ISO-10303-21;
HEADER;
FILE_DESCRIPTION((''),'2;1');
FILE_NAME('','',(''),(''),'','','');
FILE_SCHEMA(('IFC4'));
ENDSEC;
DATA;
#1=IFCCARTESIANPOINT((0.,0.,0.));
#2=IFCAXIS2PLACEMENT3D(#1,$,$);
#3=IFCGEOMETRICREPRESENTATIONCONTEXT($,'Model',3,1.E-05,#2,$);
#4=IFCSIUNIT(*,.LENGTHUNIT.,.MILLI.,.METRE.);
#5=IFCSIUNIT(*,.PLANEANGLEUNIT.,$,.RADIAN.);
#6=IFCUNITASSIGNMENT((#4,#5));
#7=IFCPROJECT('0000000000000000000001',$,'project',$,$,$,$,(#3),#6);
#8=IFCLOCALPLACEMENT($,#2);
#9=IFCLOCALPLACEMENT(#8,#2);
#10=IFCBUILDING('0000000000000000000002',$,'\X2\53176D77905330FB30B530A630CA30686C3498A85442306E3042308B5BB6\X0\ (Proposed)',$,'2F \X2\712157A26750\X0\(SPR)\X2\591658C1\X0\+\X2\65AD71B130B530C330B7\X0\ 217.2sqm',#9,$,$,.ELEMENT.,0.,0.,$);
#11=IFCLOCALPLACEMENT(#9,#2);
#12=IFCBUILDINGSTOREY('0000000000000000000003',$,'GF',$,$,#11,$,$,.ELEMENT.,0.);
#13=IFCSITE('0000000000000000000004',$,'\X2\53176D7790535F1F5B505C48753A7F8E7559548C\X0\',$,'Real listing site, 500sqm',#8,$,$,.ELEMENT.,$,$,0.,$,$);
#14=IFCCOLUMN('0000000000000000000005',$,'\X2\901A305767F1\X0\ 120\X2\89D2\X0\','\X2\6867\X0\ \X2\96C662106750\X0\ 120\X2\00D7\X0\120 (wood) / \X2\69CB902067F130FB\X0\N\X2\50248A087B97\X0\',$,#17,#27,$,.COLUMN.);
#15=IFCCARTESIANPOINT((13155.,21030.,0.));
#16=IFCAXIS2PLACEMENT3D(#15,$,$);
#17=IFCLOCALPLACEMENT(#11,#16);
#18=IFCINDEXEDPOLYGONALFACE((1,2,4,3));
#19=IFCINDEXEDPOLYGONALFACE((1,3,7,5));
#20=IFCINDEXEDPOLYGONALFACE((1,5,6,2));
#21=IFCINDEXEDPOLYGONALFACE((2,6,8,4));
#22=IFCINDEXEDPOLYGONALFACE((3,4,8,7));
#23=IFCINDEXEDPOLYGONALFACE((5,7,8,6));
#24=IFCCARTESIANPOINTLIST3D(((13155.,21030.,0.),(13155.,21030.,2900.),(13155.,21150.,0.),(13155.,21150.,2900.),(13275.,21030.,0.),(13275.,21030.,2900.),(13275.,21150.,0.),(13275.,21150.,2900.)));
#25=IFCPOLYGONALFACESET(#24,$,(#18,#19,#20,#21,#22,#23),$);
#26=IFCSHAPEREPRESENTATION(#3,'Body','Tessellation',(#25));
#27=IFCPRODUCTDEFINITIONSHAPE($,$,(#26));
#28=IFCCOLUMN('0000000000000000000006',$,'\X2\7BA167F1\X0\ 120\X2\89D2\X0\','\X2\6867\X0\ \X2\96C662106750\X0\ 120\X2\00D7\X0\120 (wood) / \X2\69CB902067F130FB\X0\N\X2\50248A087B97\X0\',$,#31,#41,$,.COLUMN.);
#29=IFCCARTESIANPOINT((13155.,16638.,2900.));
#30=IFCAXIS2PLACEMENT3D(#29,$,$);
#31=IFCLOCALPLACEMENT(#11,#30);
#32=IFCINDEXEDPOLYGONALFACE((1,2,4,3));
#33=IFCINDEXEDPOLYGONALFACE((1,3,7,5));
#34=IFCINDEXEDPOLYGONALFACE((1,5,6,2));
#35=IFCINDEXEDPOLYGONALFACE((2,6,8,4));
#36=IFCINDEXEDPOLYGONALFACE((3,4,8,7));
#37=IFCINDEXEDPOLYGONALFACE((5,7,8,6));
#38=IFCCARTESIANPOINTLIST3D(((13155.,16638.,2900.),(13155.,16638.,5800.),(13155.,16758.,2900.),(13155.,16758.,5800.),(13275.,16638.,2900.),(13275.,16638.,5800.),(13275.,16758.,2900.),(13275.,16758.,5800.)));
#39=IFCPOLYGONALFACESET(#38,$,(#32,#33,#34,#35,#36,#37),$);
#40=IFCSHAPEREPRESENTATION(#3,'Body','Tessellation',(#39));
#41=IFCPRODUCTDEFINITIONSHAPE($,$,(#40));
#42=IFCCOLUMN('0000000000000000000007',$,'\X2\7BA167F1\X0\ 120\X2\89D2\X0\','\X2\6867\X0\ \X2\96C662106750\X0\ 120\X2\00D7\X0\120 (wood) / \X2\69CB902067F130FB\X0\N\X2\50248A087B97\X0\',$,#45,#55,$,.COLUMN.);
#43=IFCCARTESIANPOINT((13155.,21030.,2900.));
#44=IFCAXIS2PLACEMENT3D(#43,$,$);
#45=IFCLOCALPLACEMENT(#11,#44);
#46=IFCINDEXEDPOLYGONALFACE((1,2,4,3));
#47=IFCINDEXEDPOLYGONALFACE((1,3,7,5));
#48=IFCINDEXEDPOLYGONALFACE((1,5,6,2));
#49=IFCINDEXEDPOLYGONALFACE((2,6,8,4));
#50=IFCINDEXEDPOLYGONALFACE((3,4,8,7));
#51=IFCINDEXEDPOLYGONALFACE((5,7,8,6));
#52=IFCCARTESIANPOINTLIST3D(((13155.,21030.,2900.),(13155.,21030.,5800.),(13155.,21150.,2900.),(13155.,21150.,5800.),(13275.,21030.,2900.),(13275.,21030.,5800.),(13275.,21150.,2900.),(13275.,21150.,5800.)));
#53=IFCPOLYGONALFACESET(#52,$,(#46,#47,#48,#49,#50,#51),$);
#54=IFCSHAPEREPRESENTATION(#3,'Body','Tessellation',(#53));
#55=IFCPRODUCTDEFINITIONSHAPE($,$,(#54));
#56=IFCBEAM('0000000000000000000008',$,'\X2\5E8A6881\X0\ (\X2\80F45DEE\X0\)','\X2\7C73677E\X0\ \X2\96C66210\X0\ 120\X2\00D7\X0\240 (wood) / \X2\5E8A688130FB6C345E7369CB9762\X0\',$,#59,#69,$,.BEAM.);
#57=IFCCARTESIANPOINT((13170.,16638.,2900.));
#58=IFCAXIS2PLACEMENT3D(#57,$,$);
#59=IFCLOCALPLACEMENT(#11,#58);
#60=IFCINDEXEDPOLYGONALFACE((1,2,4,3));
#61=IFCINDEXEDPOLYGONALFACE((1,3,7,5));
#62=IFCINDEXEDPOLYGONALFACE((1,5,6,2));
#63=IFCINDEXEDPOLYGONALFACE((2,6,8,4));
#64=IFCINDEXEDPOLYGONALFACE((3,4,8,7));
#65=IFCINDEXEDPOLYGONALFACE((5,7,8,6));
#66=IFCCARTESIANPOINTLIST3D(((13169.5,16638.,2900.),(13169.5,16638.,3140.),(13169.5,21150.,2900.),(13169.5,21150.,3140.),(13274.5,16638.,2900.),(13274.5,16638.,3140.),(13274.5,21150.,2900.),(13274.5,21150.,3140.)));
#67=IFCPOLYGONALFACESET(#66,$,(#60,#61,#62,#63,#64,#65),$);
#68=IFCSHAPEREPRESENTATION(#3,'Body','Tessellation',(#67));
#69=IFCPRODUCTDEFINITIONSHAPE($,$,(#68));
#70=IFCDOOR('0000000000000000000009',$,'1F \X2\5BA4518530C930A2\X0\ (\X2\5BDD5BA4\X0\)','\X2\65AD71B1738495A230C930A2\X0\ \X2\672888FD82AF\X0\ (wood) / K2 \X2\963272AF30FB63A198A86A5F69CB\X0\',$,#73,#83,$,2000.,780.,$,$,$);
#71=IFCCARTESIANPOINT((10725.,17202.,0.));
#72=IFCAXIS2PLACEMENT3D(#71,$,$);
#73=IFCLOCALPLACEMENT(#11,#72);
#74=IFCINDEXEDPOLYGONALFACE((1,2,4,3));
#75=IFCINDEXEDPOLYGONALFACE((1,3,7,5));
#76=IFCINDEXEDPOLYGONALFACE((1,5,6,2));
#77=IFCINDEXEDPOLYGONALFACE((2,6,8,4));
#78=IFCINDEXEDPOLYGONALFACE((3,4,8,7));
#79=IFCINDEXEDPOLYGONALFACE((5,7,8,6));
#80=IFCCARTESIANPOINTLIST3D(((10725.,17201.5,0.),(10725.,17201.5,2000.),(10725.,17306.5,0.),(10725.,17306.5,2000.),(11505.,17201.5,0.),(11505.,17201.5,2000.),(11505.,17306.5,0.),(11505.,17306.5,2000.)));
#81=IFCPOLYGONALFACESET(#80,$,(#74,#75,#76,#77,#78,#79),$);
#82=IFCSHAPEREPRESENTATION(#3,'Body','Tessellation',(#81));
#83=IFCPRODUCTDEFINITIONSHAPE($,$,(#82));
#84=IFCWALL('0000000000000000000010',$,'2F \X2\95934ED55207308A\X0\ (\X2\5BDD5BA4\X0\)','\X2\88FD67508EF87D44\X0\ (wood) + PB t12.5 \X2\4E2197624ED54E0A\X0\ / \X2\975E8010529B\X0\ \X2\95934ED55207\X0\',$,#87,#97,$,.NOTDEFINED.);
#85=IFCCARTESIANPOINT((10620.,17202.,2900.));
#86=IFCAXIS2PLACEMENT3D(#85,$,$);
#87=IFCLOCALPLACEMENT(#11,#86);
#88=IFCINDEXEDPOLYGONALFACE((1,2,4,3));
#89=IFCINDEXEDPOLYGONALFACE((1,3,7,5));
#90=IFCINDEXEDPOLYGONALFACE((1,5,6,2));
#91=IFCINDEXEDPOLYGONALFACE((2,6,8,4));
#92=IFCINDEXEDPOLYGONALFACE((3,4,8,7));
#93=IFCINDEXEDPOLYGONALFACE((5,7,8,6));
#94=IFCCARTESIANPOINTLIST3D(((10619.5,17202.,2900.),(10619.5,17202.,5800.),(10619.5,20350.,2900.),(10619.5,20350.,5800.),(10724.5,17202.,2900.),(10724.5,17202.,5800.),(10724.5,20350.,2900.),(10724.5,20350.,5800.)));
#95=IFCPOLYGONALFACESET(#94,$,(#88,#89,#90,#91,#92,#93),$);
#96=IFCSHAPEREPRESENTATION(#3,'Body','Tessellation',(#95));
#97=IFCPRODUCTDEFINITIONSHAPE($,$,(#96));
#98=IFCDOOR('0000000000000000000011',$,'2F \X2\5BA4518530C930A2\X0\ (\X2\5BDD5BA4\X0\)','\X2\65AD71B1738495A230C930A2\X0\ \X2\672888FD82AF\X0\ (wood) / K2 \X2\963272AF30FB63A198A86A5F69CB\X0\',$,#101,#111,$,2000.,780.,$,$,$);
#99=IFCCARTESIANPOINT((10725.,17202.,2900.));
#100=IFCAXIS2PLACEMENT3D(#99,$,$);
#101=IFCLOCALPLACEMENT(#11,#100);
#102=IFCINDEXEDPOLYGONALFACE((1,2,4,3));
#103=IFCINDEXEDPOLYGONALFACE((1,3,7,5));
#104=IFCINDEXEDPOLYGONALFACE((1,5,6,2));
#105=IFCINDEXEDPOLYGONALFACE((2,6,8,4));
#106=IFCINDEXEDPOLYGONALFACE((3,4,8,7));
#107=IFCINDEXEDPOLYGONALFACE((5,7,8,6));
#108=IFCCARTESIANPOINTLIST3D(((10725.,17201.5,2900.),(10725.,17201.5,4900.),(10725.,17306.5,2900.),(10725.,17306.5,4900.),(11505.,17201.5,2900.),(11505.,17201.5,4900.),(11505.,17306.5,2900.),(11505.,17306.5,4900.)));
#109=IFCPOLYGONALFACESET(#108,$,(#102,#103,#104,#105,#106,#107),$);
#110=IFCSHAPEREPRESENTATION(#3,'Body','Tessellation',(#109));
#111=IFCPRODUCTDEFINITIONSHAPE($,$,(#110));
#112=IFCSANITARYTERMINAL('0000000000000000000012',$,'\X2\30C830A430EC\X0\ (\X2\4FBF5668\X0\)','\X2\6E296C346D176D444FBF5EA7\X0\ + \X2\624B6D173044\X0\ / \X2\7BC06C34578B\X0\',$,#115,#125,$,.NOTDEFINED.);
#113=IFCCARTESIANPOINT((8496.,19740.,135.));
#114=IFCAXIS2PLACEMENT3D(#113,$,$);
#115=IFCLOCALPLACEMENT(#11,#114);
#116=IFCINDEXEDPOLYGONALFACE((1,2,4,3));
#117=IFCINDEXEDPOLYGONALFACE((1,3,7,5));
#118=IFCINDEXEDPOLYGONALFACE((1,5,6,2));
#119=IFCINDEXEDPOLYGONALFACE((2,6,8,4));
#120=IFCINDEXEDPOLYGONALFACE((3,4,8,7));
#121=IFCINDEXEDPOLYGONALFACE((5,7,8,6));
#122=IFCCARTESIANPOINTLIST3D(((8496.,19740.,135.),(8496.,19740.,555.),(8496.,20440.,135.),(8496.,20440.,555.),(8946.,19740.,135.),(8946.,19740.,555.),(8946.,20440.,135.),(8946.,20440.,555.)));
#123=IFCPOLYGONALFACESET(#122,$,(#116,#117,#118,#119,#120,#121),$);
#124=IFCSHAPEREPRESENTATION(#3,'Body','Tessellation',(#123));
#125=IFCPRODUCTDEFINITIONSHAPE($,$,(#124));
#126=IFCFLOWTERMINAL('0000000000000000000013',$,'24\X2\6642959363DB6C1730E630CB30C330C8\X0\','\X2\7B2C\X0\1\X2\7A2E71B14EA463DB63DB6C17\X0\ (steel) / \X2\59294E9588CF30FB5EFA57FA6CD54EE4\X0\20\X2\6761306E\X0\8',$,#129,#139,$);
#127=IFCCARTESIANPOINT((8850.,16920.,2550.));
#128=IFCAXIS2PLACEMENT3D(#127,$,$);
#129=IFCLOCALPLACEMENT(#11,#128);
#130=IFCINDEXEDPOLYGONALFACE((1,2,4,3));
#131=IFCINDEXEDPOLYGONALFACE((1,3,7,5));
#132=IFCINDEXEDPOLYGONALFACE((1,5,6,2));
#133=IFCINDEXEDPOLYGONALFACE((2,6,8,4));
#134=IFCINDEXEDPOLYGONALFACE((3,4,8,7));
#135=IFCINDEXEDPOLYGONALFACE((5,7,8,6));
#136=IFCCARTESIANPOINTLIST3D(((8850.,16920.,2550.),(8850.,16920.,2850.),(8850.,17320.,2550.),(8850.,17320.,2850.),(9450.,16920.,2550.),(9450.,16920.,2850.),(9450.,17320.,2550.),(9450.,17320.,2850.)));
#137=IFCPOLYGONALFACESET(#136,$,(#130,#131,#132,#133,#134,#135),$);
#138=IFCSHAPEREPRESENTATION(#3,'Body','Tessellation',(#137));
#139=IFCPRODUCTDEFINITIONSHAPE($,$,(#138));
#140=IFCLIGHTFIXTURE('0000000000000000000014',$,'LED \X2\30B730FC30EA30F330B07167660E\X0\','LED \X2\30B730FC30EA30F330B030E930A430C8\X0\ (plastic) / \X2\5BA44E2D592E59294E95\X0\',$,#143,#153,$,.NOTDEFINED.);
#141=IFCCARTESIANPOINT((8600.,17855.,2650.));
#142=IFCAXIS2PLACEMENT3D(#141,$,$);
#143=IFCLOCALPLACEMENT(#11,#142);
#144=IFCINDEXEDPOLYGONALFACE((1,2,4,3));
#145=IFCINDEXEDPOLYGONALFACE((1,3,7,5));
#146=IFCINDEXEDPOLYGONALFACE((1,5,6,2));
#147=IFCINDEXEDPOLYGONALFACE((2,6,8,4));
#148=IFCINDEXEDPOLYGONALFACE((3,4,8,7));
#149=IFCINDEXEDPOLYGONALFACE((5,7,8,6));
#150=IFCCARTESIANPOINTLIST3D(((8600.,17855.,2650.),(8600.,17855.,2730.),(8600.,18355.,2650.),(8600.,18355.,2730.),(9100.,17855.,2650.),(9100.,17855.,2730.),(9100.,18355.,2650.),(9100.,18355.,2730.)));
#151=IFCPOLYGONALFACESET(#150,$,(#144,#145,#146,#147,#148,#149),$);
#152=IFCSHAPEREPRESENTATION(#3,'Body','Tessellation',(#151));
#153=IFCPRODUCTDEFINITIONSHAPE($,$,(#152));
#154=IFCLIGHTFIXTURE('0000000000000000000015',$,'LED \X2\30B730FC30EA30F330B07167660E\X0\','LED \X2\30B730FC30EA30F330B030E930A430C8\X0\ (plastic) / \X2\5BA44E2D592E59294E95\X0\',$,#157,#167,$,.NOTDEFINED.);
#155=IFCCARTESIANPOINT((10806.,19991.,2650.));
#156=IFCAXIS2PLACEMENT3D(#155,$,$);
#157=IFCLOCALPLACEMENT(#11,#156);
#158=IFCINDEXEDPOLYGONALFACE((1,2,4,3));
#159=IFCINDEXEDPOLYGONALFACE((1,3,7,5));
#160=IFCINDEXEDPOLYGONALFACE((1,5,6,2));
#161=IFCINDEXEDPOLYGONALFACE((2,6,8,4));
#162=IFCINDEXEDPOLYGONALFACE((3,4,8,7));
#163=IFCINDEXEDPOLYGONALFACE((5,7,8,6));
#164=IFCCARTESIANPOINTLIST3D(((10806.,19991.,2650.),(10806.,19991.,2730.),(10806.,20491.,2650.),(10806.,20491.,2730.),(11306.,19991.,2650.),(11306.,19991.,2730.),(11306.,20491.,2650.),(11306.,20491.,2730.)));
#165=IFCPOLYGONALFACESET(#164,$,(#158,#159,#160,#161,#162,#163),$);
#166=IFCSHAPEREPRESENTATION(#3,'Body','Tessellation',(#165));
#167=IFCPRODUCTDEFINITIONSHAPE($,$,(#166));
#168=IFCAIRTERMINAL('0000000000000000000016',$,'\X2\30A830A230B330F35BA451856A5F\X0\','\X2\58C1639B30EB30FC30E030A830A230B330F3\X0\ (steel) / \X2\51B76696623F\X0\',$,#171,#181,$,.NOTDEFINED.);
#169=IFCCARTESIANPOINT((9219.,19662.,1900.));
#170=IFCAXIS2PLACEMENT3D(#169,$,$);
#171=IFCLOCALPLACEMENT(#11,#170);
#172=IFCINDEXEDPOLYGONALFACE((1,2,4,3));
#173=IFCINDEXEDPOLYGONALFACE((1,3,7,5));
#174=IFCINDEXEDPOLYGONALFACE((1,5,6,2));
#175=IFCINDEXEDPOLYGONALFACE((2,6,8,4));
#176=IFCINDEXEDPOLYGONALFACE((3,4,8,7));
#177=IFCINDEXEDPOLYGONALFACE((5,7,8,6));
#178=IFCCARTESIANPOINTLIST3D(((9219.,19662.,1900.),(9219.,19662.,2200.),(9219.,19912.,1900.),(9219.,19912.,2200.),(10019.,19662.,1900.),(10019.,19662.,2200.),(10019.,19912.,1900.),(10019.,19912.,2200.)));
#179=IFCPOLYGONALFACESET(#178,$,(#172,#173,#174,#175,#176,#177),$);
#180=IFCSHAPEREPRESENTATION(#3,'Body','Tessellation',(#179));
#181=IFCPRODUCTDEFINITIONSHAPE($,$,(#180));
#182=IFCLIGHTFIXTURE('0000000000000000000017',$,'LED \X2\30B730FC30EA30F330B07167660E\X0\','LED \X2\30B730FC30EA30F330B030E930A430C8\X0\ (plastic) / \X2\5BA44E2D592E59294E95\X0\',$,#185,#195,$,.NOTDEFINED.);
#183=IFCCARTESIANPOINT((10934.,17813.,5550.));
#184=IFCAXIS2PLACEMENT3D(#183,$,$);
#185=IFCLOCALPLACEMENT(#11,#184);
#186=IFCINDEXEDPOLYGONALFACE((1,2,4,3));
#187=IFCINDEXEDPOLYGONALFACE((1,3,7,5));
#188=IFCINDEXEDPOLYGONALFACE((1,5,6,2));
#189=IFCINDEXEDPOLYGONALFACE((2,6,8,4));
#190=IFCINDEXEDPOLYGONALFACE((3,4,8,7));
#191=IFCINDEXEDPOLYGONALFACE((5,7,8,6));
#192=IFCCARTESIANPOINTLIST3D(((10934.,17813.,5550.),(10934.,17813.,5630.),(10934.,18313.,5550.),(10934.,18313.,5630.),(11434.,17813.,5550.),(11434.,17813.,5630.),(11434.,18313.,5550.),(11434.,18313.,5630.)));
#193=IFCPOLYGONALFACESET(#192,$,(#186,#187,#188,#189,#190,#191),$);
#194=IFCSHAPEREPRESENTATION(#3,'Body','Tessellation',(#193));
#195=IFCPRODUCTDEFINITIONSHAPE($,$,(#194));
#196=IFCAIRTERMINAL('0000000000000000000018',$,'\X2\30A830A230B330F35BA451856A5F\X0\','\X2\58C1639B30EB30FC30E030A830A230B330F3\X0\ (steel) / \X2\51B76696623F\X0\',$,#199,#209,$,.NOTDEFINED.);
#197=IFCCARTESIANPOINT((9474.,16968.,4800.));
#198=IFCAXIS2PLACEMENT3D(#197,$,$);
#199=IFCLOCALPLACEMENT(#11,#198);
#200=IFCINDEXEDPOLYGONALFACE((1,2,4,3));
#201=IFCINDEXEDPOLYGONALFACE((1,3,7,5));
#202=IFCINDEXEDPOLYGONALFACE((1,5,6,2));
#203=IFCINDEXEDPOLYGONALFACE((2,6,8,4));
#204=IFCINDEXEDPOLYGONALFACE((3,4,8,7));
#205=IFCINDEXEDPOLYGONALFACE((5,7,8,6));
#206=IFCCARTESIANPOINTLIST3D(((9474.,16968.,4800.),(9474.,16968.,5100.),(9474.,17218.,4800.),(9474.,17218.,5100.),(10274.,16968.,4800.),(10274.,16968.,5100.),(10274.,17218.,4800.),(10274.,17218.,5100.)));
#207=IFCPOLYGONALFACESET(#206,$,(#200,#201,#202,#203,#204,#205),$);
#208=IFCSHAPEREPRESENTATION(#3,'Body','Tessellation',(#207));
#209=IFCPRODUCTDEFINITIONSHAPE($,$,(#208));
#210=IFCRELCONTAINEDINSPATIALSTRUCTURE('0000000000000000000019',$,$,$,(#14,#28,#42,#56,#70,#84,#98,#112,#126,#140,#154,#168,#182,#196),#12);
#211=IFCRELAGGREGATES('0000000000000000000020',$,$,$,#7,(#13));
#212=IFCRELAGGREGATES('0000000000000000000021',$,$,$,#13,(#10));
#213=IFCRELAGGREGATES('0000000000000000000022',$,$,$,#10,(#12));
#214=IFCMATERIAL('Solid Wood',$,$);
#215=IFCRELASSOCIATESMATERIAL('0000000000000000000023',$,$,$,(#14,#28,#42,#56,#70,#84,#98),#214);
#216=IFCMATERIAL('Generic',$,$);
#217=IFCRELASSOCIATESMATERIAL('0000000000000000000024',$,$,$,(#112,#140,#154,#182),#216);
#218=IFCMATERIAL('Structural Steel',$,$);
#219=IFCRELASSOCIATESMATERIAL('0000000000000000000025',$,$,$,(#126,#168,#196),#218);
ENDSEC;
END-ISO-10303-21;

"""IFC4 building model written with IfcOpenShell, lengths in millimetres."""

from ifc_helpers import new_model, si_unit, frame, frame_2d, origin, place, context, project, spatial, rectangle, extrude, material, element, save


model = new_model("IFC4")

# Units and contexts
model_context = context("Model", 3, precision=1e-05, world=origin())
ifc_project = project(units=[si_unit("LENGTHUNIT", "METRE", prefix="MILLI"), si_unit("PLANEANGLEUNIT", "RADIAN")], contexts=[model_context])

# Site, building, storey
site_placement = place(None, origin())
site = spatial("IfcSite", under=ifc_project, at=site_placement, Name="北海道弟子屈町美留和", ObjectType="Real listing site, 500sqm", CompositionType="ELEMENT", RefElevation=0.0)
building_placement = place(site_placement, origin())
building = spatial("IfcBuilding", under=site, at=building_placement, Name="北海道・サウナと水風呂のある家 (Proposed)", ObjectType="2F 無垢材(SPR)外壁+断熱サッシ 217.2sqm", CompositionType="ELEMENT", ElevationOfRefHeight=0.0, ElevationOfTerrain=0.0)
storey_placement = place(building_placement, origin())
storey = spatial("IfcBuildingStorey", under=building, at=storey_placement, Name="GF", CompositionType="ELEMENT", Elevation=0.0)

# Columns
ifc_material_1 = material(Name="Solid Wood")
column_1_placement = place(storey_placement, frame((13155.0, 21030.0, 0.0)))
element("IfcColumn", 1, at=column_1_placement, inside=storey, material=ifc_material_1, Name="通し柱 120角", Description="桧 集成材 120×120 (wood) / 構造柱・N値計算", PredefinedType="COLUMN", context=model_context, shape_type="SweptSolid", body=[
    extrude(rectangle(XDim=120.0, YDim=120.0, at=frame_2d((60.0, 60.0))), frame((13155.0, 21030.0, 0.0)), (0.0, 0.0, 1.0), 2900.0),
])
column_2_placement = place(storey_placement, frame((13155.0, 16638.0, 2900.0)))
element("IfcColumn", 2, at=column_2_placement, inside=storey, material=ifc_material_1, Name="管柱 120角", Description="桧 集成材 120×120 (wood) / 構造柱・N値計算", PredefinedType="COLUMN", context=model_context, shape_type="SweptSolid", body=[
    extrude(rectangle(XDim=120.0, YDim=120.0, at=frame_2d((60.0, 60.0))), frame((13155.0, 16638.0, 2900.0)), (0.0, 0.0, 1.0), 2900.0),
])
column_3_placement = place(storey_placement, frame((13155.0, 21030.0, 2900.0)))
element("IfcColumn", 3, at=column_3_placement, inside=storey, material=ifc_material_1, Name="管柱 120角", Description="桧 集成材 120×120 (wood) / 構造柱・N値計算", PredefinedType="COLUMN", context=model_context, shape_type="SweptSolid", body=[
    extrude(rectangle(XDim=120.0, YDim=120.0, at=frame_2d((60.0, 60.0))), frame((13155.0, 21030.0, 2900.0)), (0.0, 0.0, 1.0), 2900.0),
])

# Beam
beam_1_placement = place(storey_placement, frame((13170.0, 16638.0, 2900.0)))
element("IfcBeam", 4, at=beam_1_placement, inside=storey, material=ifc_material_1, Name="床梁 (胴差)", Description="米松 集成 120×240 (wood) / 床梁・水平構面", PredefinedType="BEAM", context=model_context, shape_type="SweptSolid", body=[
    extrude(rectangle(XDim=105.0, YDim=4512.0, at=frame_2d((52.0, 2256.0))), frame((13170.0, 16638.0, 2900.0)), (0.0, 0.0, 1.0), 240.0),
])

# Door
door_1_placement = place(storey_placement, frame((10725.0, 17202.0, 0.0)))
element("IfcDoor", 5, at=door_1_placement, inside=storey, material=ifc_material_1, Name="1F 室内ドア (寝室)", Description="断熱玄関ドア 木製芯 (wood) / K2 防犯・採風機構", OverallHeight=2000.0, OverallWidth=780.0, context=model_context, shape_type="SweptSolid", body=[
    extrude(rectangle(XDim=780.0, YDim=105.0, at=frame_2d((390.0, 52.0))), frame((10725.0, 17202.0, 0.0)), (0.0, 0.0, 1.0), 2000.0),
])

# Wall
wall_1_placement = place(storey_placement, frame((10620.0, 17202.0, 2900.0)))
element("IfcWall", 6, at=wall_1_placement, inside=storey, material=ifc_material_1, Name="2F 間仕切り (寝室)", Description="製材軸組 (wood) + PB t12.5 両面仕上 / 非耐力 間仕切", PredefinedType="NOTDEFINED", context=model_context, shape_type="SweptSolid", body=[
    extrude(rectangle(XDim=105.0, YDim=3148.0, at=frame_2d((52.0, 1574.0))), frame((10620.0, 17202.0, 2900.0)), (0.0, 0.0, 1.0), 2900.0),
])

# Door
door_2_placement = place(storey_placement, frame((10725.0, 17202.0, 2900.0)))
element("IfcDoor", 7, at=door_2_placement, inside=storey, material=ifc_material_1, Name="2F 室内ドア (寝室)", Description="断熱玄関ドア 木製芯 (wood) / K2 防犯・採風機構", OverallHeight=2000.0, OverallWidth=780.0, context=model_context, shape_type="SweptSolid", body=[
    extrude(rectangle(XDim=780.0, YDim=105.0, at=frame_2d((390.0, 52.0))), frame((10725.0, 17202.0, 2900.0)), (0.0, 0.0, 1.0), 2000.0),
])

# Sanitary terminal
ifc_material_2 = material(Name="Generic")
sanitary_terminal_placement = place(storey_placement, frame((8496.0, 19740.0, 135.0)))
element("IfcSanitaryTerminal", 8, at=sanitary_terminal_placement, inside=storey, material=ifc_material_2, Name="トイレ (便器)", Description="温水洗浄便座 + 手洗い / 節水型", PredefinedType="NOTDEFINED", context=model_context, shape_type="SweptSolid", body=[
    extrude(rectangle(XDim=450.0, YDim=700.0, at=frame_2d((225.0, 350.0))), frame((8496.0, 19740.0, 135.0)), (0.0, 0.0, 1.0), 420.0),
])

# Flow terminal
ifc_material_3 = material(Name="Structural Steel")
flow_terminal_placement = place(storey_placement, frame((8850.0, 16920.0, 2550.0)))
element("IfcFlowTerminal", 9, at=flow_terminal_placement, inside=storey, material=ifc_material_3, Name="24時間換気ユニット", Description="第1種熱交換換気 (steel) / 天井裏・建基法令20条の8", context=model_context, shape_type="SweptSolid", body=[
    extrude(rectangle(XDim=600.0, YDim=400.0, at=frame_2d((300.0, 200.0))), frame((8850.0, 16920.0, 2550.0)), (0.0, 0.0, 1.0), 300.0),
])

# Light fixtures
light_fixture_1_placement = place(storey_placement, frame((8600.0, 17855.0, 2650.0)))
element("IfcLightFixture", 10, at=light_fixture_1_placement, inside=storey, material=ifc_material_2, Name="LED シーリング照明", Description="LED シーリングライト (plastic) / 室中央天井", PredefinedType="NOTDEFINED", context=model_context, shape_type="SweptSolid", body=[
    extrude(rectangle(XDim=500.0, YDim=500.0, at=frame_2d((250.0, 250.0))), frame((8600.0, 17855.0, 2650.0)), (0.0, 0.0, 1.0), 80.0),
])
light_fixture_2_placement = place(storey_placement, frame((10806.0, 19991.0, 2650.0)))
element("IfcLightFixture", 11, at=light_fixture_2_placement, inside=storey, material=ifc_material_2, Name="LED シーリング照明", Description="LED シーリングライト (plastic) / 室中央天井", PredefinedType="NOTDEFINED", context=model_context, shape_type="SweptSolid", body=[
    extrude(rectangle(XDim=500.0, YDim=500.0, at=frame_2d((250.0, 250.0))), frame((10806.0, 19991.0, 2650.0)), (0.0, 0.0, 1.0), 80.0),
])

# Air terminal
air_terminal_1_placement = place(storey_placement, frame((9219.0, 19662.0, 1900.0)))
element("IfcAirTerminal", 12, at=air_terminal_1_placement, inside=storey, material=ifc_material_3, Name="エアコン室内機", Description="壁掛ルームエアコン (steel) / 冷暖房", PredefinedType="NOTDEFINED", context=model_context, shape_type="SweptSolid", body=[
    extrude(rectangle(XDim=800.0, YDim=250.0, at=frame_2d((400.0, 125.0))), frame((9219.0, 19662.0, 1900.0)), (0.0, 0.0, 1.0), 300.0),
])

# Light fixture
light_fixture_3_placement = place(storey_placement, frame((10934.0, 17813.0, 5550.0)))
element("IfcLightFixture", 13, at=light_fixture_3_placement, inside=storey, material=ifc_material_2, Name="LED シーリング照明", Description="LED シーリングライト (plastic) / 室中央天井", PredefinedType="NOTDEFINED", context=model_context, shape_type="SweptSolid", body=[
    extrude(rectangle(XDim=500.0, YDim=500.0, at=frame_2d((250.0, 250.0))), frame((10934.0, 17813.0, 5550.0)), (0.0, 0.0, 1.0), 80.0),
])

# Air terminal
air_terminal_2_placement = place(storey_placement, frame((9474.0, 16968.0, 4800.0)))
element("IfcAirTerminal", 14, at=air_terminal_2_placement, inside=storey, material=ifc_material_3, Name="エアコン室内機", Description="壁掛ルームエアコン (steel) / 冷暖房", PredefinedType="NOTDEFINED", context=model_context, shape_type="SweptSolid", body=[
    extrude(rectangle(XDim=800.0, YDim=250.0, at=frame_2d((400.0, 125.0))), frame((9474.0, 16968.0, 4800.0)), (0.0, 0.0, 1.0), 300.0),
])

save(model, "model.ifc")
